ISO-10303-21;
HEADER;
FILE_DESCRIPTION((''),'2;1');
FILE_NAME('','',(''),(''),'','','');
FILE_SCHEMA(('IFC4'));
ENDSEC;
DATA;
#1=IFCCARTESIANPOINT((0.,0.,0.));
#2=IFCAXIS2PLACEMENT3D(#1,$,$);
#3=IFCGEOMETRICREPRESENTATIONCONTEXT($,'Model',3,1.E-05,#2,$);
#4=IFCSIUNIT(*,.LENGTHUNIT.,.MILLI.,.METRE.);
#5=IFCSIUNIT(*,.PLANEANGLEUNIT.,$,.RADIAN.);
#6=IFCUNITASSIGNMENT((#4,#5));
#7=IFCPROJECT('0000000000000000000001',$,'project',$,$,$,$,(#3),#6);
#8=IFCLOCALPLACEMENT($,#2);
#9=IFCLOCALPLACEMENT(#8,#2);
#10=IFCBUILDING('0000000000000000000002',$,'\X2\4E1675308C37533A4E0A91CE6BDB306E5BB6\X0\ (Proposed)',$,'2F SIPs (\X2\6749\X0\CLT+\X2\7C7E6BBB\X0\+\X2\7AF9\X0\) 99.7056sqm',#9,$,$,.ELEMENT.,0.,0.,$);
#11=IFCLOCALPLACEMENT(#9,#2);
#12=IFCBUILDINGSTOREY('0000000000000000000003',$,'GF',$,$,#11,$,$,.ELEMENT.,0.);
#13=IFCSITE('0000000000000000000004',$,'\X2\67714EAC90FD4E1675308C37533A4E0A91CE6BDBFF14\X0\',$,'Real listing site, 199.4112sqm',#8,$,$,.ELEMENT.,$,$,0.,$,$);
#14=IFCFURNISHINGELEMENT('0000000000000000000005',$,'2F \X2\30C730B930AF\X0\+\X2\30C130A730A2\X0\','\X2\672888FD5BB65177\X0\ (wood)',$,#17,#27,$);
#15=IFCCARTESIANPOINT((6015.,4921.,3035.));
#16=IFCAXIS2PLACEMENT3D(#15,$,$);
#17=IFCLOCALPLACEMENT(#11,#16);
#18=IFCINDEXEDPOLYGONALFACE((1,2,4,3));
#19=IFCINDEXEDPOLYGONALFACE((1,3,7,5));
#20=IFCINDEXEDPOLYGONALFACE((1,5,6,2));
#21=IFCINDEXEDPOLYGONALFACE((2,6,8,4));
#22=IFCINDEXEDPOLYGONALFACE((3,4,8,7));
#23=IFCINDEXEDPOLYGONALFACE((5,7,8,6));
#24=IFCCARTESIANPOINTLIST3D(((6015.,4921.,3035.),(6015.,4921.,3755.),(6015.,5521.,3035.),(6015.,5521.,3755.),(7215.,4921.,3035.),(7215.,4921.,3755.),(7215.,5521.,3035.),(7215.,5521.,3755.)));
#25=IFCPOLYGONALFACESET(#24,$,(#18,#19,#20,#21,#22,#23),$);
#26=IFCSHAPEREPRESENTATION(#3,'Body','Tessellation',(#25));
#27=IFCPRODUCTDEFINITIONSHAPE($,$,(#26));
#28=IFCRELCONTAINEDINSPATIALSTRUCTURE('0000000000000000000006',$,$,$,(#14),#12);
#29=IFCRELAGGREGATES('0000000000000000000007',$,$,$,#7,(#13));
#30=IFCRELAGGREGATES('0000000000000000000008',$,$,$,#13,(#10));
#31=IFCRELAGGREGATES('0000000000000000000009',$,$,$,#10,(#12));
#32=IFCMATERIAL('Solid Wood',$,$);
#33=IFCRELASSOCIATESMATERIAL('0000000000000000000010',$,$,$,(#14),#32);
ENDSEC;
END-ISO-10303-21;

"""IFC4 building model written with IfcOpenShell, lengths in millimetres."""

from ifc_helpers import new_model, si_unit, frame, frame_2d, origin, place, context, project, spatial, rectangle, extrude, material, element, save


model = new_model("IFC4")

# Units and contexts
model_context = context("Model", 3, precision=1e-05, world=origin())
ifc_project = project(units=[si_unit("LENGTHUNIT", "METRE", prefix="MILLI"), si_unit("PLANEANGLEUNIT", "RADIAN")], contexts=[model_context])

# Site, building, storey
site_placement = place(None, origin())
site = spatial("IfcSite", under=ifc_project, at=site_placement, Name="東京都世田谷区上野毛４", ObjectType="Real listing site, 199.4112sqm", CompositionType="ELEMENT", RefElevation=0.0)
building_placement = place(site_placement, origin())
building = spatial("IfcBuilding", under=site, at=building_placement, Name="世田谷区上野毛の家 (Proposed)", ObjectType="2F SIPs (杉CLT+籾殻+竹) 99.7056sqm", CompositionType="ELEMENT", ElevationOfRefHeight=0.0, ElevationOfTerrain=0.0)
storey_placement = place(building_placement, origin())
storey = spatial("IfcBuildingStorey", under=building, at=storey_placement, Name="GF", CompositionType="ELEMENT", Elevation=0.0)

# Shared definitions
ifc_material_1 = material(Name="Solid Wood")

# Furnishing element
furnishing_1_placement = place(storey_placement, frame((6015.0, 4921.0, 3035.0)))
element("IfcFurnishingElement", 1, at=furnishing_1_placement, inside=storey, material=ifc_material_1, Name="2F デスク+チェア", Description="木製家具 (wood)", context=model_context, shape_type="SweptSolid", body=[
    extrude(rectangle(XDim=1200.0, YDim=600.0, at=frame_2d((600.0, 300.0))), frame((6015.0, 4921.0, 3035.0)), (0.0, 0.0, 1.0), 720.0),
])

save(model, "model.ifc")
